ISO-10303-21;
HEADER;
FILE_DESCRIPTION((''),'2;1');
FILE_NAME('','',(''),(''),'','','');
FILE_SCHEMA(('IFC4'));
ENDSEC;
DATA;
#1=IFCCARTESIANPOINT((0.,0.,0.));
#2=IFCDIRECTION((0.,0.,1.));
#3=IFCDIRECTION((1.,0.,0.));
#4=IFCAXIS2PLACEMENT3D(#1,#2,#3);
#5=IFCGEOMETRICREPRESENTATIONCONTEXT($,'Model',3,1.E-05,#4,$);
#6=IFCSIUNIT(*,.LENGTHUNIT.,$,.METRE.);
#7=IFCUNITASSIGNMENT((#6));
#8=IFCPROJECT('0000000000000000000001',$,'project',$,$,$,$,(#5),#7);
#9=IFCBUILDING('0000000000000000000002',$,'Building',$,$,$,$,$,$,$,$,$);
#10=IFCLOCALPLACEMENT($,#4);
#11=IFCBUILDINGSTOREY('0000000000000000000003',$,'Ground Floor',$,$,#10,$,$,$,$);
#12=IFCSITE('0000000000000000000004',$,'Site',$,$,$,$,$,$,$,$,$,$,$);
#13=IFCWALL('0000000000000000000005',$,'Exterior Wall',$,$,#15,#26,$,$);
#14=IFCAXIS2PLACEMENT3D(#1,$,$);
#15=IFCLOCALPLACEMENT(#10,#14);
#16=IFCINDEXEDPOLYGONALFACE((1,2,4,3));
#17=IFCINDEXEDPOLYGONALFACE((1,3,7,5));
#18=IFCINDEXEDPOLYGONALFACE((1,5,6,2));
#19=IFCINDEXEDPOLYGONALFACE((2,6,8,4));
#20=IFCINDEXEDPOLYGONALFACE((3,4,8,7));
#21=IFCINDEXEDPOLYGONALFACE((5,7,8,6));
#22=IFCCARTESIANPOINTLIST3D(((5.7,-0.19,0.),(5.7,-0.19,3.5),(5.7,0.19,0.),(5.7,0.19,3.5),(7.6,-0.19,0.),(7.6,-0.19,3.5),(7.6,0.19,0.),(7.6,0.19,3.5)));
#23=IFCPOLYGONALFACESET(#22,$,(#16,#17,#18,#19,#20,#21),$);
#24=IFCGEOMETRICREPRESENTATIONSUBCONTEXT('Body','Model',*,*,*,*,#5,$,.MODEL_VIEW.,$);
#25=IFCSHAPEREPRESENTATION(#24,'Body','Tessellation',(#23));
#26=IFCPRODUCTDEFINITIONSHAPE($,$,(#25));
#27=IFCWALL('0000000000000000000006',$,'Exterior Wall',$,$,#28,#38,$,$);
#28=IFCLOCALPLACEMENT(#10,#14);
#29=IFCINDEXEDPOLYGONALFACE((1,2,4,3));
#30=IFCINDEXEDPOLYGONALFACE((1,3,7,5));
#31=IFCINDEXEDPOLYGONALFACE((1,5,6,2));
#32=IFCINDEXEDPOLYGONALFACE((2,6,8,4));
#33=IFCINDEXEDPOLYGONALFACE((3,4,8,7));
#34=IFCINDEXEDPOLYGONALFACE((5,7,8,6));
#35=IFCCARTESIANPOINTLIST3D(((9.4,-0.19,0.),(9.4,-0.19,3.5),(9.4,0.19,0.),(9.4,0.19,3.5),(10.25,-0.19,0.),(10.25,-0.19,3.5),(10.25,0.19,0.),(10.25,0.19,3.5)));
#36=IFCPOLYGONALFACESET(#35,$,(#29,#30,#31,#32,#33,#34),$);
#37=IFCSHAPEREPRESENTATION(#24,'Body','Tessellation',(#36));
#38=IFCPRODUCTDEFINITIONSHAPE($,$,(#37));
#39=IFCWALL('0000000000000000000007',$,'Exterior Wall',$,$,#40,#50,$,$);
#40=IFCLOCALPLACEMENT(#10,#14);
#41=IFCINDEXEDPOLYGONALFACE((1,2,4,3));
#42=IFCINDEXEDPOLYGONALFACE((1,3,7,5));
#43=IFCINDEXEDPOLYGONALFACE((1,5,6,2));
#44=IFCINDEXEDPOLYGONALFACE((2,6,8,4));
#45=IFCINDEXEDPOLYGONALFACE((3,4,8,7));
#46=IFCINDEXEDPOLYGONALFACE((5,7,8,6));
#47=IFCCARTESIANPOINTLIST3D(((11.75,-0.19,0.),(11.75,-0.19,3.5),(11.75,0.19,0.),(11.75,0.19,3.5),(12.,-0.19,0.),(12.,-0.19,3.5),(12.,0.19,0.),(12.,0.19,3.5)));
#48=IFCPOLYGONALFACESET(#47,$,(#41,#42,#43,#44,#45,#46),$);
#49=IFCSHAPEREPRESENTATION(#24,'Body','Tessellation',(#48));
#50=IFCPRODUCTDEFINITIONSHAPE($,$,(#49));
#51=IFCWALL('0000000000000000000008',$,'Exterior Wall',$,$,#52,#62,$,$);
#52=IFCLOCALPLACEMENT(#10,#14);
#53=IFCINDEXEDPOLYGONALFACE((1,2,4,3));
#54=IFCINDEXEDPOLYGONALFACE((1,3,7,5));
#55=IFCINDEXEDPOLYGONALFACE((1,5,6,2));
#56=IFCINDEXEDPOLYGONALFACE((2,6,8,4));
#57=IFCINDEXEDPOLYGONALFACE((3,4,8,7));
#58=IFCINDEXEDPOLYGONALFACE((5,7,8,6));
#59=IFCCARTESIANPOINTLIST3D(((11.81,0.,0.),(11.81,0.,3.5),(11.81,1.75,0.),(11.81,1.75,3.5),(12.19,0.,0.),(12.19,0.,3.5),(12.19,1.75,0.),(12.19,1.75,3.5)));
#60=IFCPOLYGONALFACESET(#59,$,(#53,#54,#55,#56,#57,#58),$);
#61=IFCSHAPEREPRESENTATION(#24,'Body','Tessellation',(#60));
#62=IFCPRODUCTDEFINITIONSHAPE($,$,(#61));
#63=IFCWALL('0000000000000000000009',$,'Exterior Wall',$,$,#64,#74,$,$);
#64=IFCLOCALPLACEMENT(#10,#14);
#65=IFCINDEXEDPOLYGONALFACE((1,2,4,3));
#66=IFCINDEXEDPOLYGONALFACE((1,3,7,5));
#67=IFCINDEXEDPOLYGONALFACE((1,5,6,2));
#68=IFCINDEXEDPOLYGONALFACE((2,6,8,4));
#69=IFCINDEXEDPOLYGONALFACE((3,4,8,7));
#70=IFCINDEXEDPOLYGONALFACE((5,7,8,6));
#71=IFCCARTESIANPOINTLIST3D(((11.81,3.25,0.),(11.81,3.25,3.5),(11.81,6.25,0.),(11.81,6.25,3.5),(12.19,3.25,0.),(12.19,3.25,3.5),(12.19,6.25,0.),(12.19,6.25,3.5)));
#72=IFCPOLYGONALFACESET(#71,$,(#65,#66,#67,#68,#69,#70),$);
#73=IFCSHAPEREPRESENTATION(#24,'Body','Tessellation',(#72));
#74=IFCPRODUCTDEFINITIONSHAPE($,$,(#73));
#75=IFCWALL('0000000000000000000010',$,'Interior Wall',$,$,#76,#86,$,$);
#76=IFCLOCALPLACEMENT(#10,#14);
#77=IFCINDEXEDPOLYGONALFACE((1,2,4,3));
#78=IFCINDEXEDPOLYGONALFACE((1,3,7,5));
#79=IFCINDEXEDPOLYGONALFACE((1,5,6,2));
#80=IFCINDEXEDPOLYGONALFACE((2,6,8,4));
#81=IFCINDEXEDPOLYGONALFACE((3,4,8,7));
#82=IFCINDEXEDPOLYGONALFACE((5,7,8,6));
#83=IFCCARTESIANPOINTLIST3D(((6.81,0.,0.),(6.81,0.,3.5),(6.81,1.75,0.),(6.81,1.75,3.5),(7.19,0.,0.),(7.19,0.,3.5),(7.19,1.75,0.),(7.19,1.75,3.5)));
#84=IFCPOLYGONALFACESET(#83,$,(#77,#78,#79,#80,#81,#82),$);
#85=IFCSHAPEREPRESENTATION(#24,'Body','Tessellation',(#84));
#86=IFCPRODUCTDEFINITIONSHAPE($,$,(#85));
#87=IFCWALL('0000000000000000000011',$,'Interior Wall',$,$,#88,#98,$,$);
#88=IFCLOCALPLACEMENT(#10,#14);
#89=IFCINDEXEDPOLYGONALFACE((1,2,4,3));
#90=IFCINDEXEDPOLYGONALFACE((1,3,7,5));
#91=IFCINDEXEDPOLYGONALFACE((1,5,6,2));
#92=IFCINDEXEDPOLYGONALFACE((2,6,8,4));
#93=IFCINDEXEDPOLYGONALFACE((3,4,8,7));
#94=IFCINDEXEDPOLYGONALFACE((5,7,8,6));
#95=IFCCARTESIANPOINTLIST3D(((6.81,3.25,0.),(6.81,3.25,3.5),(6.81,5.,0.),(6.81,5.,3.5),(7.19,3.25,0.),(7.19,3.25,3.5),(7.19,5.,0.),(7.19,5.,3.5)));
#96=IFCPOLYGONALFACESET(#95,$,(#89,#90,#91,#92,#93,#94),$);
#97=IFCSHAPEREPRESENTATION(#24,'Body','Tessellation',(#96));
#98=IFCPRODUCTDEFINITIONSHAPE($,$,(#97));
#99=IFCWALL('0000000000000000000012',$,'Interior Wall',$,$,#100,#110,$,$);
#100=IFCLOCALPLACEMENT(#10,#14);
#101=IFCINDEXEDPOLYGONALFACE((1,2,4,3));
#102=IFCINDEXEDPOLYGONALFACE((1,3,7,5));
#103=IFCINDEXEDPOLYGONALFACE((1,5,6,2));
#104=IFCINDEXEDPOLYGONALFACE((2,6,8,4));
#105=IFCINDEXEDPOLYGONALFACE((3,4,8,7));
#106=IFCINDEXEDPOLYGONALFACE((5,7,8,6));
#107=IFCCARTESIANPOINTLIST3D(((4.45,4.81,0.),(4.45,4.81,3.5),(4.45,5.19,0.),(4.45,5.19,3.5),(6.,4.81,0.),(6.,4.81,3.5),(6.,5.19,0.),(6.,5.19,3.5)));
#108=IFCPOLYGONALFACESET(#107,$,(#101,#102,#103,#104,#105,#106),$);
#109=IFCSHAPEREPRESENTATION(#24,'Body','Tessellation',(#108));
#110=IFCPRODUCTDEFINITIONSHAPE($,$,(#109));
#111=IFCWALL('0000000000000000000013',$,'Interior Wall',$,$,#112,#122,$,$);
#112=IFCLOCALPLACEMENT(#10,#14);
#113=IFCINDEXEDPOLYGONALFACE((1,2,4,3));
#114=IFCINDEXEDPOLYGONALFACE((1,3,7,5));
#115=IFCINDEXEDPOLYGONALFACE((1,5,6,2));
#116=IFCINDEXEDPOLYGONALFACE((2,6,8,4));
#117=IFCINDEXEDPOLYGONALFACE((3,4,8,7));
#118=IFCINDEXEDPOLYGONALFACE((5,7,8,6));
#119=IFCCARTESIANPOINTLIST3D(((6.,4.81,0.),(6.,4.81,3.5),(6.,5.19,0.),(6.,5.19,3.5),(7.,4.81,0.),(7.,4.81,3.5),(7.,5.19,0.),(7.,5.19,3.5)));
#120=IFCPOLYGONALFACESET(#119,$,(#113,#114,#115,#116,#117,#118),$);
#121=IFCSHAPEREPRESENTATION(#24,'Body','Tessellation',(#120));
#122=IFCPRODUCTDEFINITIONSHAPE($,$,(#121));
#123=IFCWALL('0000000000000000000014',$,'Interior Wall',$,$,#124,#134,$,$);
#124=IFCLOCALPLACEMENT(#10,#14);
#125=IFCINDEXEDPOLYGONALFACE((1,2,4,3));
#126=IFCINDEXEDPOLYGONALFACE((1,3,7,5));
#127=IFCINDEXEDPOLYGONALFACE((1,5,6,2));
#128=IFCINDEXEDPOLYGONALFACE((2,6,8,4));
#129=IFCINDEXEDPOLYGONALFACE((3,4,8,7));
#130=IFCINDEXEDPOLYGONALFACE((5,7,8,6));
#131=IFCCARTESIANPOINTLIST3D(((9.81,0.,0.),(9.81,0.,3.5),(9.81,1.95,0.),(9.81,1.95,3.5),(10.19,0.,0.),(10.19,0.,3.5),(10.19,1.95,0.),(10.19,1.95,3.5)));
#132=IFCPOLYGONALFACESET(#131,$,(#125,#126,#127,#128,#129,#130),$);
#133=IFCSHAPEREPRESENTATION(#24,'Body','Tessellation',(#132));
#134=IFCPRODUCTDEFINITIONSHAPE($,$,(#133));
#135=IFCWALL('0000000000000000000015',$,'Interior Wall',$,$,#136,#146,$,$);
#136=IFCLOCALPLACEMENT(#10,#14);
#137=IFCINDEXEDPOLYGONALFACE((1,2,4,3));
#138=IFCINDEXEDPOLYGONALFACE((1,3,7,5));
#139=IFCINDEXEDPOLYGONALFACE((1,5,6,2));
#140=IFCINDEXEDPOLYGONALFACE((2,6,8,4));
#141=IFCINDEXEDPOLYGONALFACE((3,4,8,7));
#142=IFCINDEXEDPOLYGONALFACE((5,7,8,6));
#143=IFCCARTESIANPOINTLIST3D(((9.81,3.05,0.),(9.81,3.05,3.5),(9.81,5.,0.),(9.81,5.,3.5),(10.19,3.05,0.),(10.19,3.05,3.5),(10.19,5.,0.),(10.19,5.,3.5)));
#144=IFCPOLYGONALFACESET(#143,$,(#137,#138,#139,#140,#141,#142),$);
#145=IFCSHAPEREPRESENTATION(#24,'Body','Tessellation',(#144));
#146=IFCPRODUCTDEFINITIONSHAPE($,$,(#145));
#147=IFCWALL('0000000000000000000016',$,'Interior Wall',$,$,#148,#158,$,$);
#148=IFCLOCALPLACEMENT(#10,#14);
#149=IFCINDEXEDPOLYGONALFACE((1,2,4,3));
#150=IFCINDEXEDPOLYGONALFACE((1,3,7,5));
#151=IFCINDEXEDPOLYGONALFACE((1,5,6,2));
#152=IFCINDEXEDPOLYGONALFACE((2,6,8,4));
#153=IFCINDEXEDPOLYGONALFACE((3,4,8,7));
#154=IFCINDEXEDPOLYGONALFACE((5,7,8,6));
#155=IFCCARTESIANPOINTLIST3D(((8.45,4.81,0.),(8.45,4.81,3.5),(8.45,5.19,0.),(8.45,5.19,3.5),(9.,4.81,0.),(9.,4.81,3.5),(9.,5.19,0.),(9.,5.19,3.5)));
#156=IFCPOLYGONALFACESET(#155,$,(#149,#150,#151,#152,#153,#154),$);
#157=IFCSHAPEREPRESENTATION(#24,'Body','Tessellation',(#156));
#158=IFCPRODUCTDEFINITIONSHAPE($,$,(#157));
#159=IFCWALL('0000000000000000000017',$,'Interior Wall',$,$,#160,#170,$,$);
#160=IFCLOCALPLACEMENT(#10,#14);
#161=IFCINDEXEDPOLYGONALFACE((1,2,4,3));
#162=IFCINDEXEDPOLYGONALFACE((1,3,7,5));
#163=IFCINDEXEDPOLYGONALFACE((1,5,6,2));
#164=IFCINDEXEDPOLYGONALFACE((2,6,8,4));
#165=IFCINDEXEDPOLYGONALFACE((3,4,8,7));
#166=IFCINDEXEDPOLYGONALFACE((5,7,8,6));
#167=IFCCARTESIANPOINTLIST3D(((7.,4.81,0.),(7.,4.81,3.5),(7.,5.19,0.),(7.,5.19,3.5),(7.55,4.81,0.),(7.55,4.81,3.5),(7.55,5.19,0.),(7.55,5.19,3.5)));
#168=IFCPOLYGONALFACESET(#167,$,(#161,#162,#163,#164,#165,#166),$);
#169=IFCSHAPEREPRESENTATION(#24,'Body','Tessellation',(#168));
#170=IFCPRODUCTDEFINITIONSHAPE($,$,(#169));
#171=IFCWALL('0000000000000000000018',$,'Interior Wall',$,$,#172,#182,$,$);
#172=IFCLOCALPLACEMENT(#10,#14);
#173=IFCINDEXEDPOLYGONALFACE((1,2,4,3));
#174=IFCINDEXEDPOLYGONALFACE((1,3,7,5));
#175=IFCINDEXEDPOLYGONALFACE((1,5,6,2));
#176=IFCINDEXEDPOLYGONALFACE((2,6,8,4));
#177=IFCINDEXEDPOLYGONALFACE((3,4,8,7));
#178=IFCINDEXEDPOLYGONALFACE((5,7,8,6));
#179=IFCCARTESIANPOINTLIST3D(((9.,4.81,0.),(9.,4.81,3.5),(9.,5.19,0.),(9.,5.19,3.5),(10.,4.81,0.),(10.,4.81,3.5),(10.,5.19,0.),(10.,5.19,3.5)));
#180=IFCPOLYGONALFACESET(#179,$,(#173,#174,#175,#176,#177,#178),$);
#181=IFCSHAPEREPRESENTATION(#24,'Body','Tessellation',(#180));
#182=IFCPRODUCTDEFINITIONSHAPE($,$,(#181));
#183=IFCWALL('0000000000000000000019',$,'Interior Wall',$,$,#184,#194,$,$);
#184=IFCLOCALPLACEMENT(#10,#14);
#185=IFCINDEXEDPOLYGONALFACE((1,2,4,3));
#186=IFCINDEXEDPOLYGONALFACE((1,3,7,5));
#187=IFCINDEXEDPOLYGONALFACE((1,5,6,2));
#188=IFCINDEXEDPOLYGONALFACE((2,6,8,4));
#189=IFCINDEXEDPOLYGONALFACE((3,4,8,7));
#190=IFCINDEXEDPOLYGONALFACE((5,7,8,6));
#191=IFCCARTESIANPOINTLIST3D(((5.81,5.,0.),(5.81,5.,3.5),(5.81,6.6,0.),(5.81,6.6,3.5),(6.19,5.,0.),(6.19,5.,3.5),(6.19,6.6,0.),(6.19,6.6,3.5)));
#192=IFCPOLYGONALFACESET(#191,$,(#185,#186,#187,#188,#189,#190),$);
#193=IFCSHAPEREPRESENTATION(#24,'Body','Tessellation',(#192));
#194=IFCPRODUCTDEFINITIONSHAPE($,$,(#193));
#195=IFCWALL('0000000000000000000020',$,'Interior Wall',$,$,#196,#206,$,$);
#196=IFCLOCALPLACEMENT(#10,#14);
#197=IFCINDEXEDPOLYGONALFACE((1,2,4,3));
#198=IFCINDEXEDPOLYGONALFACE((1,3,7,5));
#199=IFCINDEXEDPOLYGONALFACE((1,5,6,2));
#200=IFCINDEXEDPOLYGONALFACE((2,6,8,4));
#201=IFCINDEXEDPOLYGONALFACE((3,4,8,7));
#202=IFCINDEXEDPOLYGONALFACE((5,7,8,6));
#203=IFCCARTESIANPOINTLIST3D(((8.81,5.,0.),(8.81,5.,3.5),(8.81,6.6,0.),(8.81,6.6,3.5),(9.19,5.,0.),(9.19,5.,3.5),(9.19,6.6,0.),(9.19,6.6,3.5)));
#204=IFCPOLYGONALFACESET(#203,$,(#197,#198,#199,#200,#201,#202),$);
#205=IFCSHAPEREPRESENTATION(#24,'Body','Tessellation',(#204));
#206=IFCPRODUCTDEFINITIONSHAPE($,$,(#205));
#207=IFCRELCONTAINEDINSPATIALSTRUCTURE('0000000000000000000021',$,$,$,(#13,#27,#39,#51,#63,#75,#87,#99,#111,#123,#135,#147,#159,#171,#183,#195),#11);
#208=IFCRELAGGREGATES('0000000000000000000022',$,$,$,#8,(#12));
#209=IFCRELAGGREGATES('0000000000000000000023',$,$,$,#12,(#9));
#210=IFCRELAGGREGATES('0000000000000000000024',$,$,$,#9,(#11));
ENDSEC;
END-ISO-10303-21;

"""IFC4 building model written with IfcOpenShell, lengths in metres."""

from ifc_helpers import new_model, si_unit, frame, origin_with_axes, place, context, subcontext, project, spatial, indexed_curve, outline, extrude, element, save


model = new_model("IFC4")

# Units and contexts
model_context = context("Model", 3, precision=1e-05, world=origin_with_axes())
body_context = subcontext(model_context, "Body", "Model", "MODEL_VIEW")
ifc_project = project(units=[si_unit("LENGTHUNIT", "METRE")], contexts=[model_context])

# Site, building, storey
site = spatial("IfcSite", under=ifc_project, Name="Site")
building = spatial("IfcBuilding", under=site, Name="Building")
storey_placement = place(None, origin_with_axes())
storey = spatial("IfcBuildingStorey", under=building, at=storey_placement, Name="Ground Floor")

# Walls
wall_1_placement = place(storey_placement, frame((5.7, 0.0, 0.0), z_axis=(0.0, 0.0, 1.0), x_axis=(1.0, 0.0, 0.0)))
element("IfcWall", 1, at=wall_1_placement, inside=storey, Name="Exterior Wall", context=body_context, shape_type="SweptSolid", body=[
    extrude(outline(indexed_curve([(0.0, 0.0), (0.0, 0.38), (1.9, 0.38), (1.9, 0.0), (0.0, 0.0)], self_intersect=False)), frame((0.0, -0.19, 0.0), z_axis=(0.0, 0.0, 1.0), x_axis=(1.0, 0.0, 0.0)), (0.0, 0.0, 1.0), 3.5),
])
wall_2_placement = place(storey_placement, frame((9.4, 0.0, 0.0), z_axis=(0.0, 0.0, 1.0), x_axis=(1.0, 0.0, 0.0)))
element("IfcWall", 2, at=wall_2_placement, inside=storey, Name="Exterior Wall", context=body_context, shape_type="SweptSolid", body=[
    extrude(outline(indexed_curve([(0.0, 0.0), (0.0, 0.38), (0.85, 0.38), (0.85, 0.0), (0.0, 0.0)], self_intersect=False)), frame((0.0, -0.19, 0.0), z_axis=(0.0, 0.0, 1.0), x_axis=(1.0, 0.0, 0.0)), (0.0, 0.0, 1.0), 3.5),
])
wall_3_placement = place(storey_placement, frame((11.75, 0.0, 0.0), z_axis=(0.0, 0.0, 1.0), x_axis=(1.0, 0.0, 0.0)))
element("IfcWall", 3, at=wall_3_placement, inside=storey, Name="Exterior Wall", context=body_context, shape_type="SweptSolid", body=[
    extrude(outline(indexed_curve([(0.0, 0.0), (0.0, 0.38), (0.25, 0.38), (0.25, 0.0), (0.0, 0.0)], self_intersect=False)), frame((0.0, -0.19, 0.0), z_axis=(0.0, 0.0, 1.0), x_axis=(1.0, 0.0, 0.0)), (0.0, 0.0, 1.0), 3.5),
])
wall_4_placement = place(storey_placement, frame((12.0, 0.0, 0.0), z_axis=(0.0, 0.0, 1.0), x_axis=(0.0, 1.0, 0.0)))
element("IfcWall", 4, at=wall_4_placement, inside=storey, Name="Exterior Wall", context=body_context, shape_type="SweptSolid", body=[
    extrude(outline(indexed_curve([(0.0, 0.0), (0.0, 0.38), (1.75, 0.38), (1.75, 0.0), (0.0, 0.0)], self_intersect=False)), frame((0.0, -0.19, 0.0), z_axis=(0.0, 0.0, 1.0), x_axis=(1.0, 0.0, 0.0)), (0.0, 0.0, 1.0), 3.5),
])
wall_5_placement = place(storey_placement, frame((12.0, 3.25, 0.0), z_axis=(0.0, 0.0, 1.0), x_axis=(0.0, 1.0, 0.0)))
element("IfcWall", 5, at=wall_5_placement, inside=storey, Name="Exterior Wall", context=body_context, shape_type="SweptSolid", body=[
    extrude(outline(indexed_curve([(0.0, 0.0), (0.0, 0.38), (3.0, 0.38), (3.0, 0.0), (0.0, 0.0)], self_intersect=False)), frame((0.0, -0.19, 0.0), z_axis=(0.0, 0.0, 1.0), x_axis=(1.0, 0.0, 0.0)), (0.0, 0.0, 1.0), 3.5),
])
for number, where, z_axis, x_axis, name in (
    (6, (7.0, 0.0, 0.0), (0.0, 0.0, 1.0), (0.0, 1.0, 0.0), "Interior Wall"),
    (7, (7.0, 3.25, 0.0), (0.0, 0.0, 1.0), (0.0, 1.0, 0.0), "Interior Wall"),
):
    element("IfcWall", number, at=place(storey_placement, frame(where, z_axis=z_axis, x_axis=x_axis)), inside=storey, Name=name, context=body_context, shape_type="SweptSolid", body=[
        extrude(outline(indexed_curve([(0.0, 0.0), (0.0, 0.38), (1.75, 0.38), (1.75, 0.0), (0.0, 0.0)], self_intersect=False)), frame((0.0, -0.19, 0.0), z_axis=(0.0, 0.0, 1.0), x_axis=(1.0, 0.0, 0.0)), (0.0, 0.0, 1.0), 3.5),
    ])
wall_6_placement = place(storey_placement, frame((6.0, 5.0, 0.0), z_axis=(0.0, 0.0, 1.0), x_axis=(-1.0, 0.0, 0.0)))
element("IfcWall", 8, at=wall_6_placement, inside=storey, Name="Interior Wall", context=body_context, shape_type="SweptSolid", body=[
    extrude(outline(indexed_curve([(0.0, 0.0), (0.0, 0.38), (1.55, 0.38), (1.55, 0.0), (0.0, 0.0)], self_intersect=False)), frame((0.0, -0.19, 0.0), z_axis=(0.0, 0.0, 1.0), x_axis=(1.0, 0.0, 0.0)), (0.0, 0.0, 1.0), 3.5),
])
wall_7_placement = place(storey_placement, frame((7.0, 5.0, 0.0), z_axis=(0.0, 0.0, 1.0), x_axis=(-1.0, 0.0, 0.0)))
element("IfcWall", 9, at=wall_7_placement, inside=storey, Name="Interior Wall", context=body_context, shape_type="SweptSolid", body=[
    extrude(outline(indexed_curve([(0.0, 0.0), (0.0, 0.38), (1.0, 0.38), (1.0, 0.0), (0.0, 0.0)], self_intersect=False)), frame((0.0, -0.19, 0.0), z_axis=(0.0, 0.0, 1.0), x_axis=(1.0, 0.0, 0.0)), (0.0, 0.0, 1.0), 3.5),
])
wall_8_placement = place(storey_placement, frame((10.0, 0.0, 0.0), z_axis=(0.0, 0.0, 1.0), x_axis=(0.0, 1.0, 0.0)))
element("IfcWall", 10, at=wall_8_placement, inside=storey, Name="Interior Wall", context=body_context, shape_type="SweptSolid", body=[
    extrude(outline(indexed_curve([(0.0, 0.0), (0.0, 0.38), (1.95, 0.38), (1.95, 0.0), (0.0, 0.0)], self_intersect=False)), frame((0.0, -0.19, 0.0), z_axis=(0.0, 0.0, 1.0), x_axis=(1.0, 0.0, 0.0)), (0.0, 0.0, 1.0), 3.5),
])
wall_9_placement = place(storey_placement, frame((10.0, 3.05, 0.0), z_axis=(0.0, 0.0, 1.0), x_axis=(0.0, 1.0, 0.0)))
element("IfcWall", 11, at=wall_9_placement, inside=storey, Name="Interior Wall", context=body_context, shape_type="SweptSolid", body=[
    extrude(outline(indexed_curve([(0.0, 0.0), (0.0, 0.38), (1.95, 0.38), (1.95, 0.0), (0.0, 0.0)], self_intersect=False)), frame((0.0, -0.19, 0.0), z_axis=(0.0, 0.0, 1.0), x_axis=(1.0, 0.0, 0.0)), (0.0, 0.0, 1.0), 3.5),
])
wall_10_placement = place(storey_placement, frame((9.0, 5.0, 0.0), z_axis=(0.0, 0.0, 1.0), x_axis=(-1.0, 0.0, 0.0)))
element("IfcWall", 12, at=wall_10_placement, inside=storey, Name="Interior Wall", context=body_context, shape_type="SweptSolid", body=[
    extrude(outline(indexed_curve([(0.0, 0.0), (0.0, 0.38), (0.55, 0.38), (0.55, 0.0), (0.0, 0.0)], self_intersect=False)), frame((0.0, -0.19, 0.0), z_axis=(0.0, 0.0, 1.0), x_axis=(1.0, 0.0, 0.0)), (0.0, 0.0, 1.0), 3.5),
])
wall_11_placement = place(storey_placement, frame((7.55, 5.0, 0.0), z_axis=(0.0, 0.0, 1.0), x_axis=(-1.0, 0.0, 0.0)))
element("IfcWall", 13, at=wall_11_placement, inside=storey, Name="Interior Wall", context=body_context, shape_type="SweptSolid", body=[
    extrude(outline(indexed_curve([(0.0, 0.0), (0.0, 0.38), (0.55, 0.38), (0.55, 0.0), (0.0, 0.0)], self_intersect=False)), frame((0.0, -0.19, 0.0), z_axis=(0.0, 0.0, 1.0), x_axis=(1.0, 0.0, 0.0)), (0.0, 0.0, 1.0), 3.5),
])
wall_12_placement = place(storey_placement, frame((10.0, 5.0, 0.0), z_axis=(0.0, 0.0, 1.0), x_axis=(-1.0, 0.0, 0.0)))
element("IfcWall", 14, at=wall_12_placement, inside=storey, Name="Interior Wall", context=body_context, shape_type="SweptSolid", body=[
    extrude(outline(indexed_curve([(0.0, 0.0), (0.0, 0.38), (1.0, 0.38), (1.0, 0.0), (0.0, 0.0)], self_intersect=False)), frame((0.0, -0.19, 0.0), z_axis=(0.0, 0.0, 1.0), x_axis=(1.0, 0.0, 0.0)), (0.0, 0.0, 1.0), 3.5),
])
for number, where, z_axis, x_axis, name in (
    (15, (6.0, 5.0, 0.0), (0.0, 0.0, 1.0), (0.0, 1.0, 0.0), "Interior Wall"),
    (16, (9.0, 5.0, 0.0), (0.0, 0.0, 1.0), (0.0, 1.0, 0.0), "Interior Wall"),
):
    element("IfcWall", number, at=place(storey_placement, frame(where, z_axis=z_axis, x_axis=x_axis)), inside=storey, Name=name, context=body_context, shape_type="SweptSolid", body=[
        extrude(outline(indexed_curve([(0.0, 0.0), (0.0, 0.38), (1.6, 0.38), (1.6, 0.0), (0.0, 0.0)], self_intersect=False)), frame((0.0, -0.19, 0.0), z_axis=(0.0, 0.0, 1.0), x_axis=(1.0, 0.0, 0.0)), (0.0, 0.0, 1.0), 3.5),
    ])

save(model, "model.ifc")
